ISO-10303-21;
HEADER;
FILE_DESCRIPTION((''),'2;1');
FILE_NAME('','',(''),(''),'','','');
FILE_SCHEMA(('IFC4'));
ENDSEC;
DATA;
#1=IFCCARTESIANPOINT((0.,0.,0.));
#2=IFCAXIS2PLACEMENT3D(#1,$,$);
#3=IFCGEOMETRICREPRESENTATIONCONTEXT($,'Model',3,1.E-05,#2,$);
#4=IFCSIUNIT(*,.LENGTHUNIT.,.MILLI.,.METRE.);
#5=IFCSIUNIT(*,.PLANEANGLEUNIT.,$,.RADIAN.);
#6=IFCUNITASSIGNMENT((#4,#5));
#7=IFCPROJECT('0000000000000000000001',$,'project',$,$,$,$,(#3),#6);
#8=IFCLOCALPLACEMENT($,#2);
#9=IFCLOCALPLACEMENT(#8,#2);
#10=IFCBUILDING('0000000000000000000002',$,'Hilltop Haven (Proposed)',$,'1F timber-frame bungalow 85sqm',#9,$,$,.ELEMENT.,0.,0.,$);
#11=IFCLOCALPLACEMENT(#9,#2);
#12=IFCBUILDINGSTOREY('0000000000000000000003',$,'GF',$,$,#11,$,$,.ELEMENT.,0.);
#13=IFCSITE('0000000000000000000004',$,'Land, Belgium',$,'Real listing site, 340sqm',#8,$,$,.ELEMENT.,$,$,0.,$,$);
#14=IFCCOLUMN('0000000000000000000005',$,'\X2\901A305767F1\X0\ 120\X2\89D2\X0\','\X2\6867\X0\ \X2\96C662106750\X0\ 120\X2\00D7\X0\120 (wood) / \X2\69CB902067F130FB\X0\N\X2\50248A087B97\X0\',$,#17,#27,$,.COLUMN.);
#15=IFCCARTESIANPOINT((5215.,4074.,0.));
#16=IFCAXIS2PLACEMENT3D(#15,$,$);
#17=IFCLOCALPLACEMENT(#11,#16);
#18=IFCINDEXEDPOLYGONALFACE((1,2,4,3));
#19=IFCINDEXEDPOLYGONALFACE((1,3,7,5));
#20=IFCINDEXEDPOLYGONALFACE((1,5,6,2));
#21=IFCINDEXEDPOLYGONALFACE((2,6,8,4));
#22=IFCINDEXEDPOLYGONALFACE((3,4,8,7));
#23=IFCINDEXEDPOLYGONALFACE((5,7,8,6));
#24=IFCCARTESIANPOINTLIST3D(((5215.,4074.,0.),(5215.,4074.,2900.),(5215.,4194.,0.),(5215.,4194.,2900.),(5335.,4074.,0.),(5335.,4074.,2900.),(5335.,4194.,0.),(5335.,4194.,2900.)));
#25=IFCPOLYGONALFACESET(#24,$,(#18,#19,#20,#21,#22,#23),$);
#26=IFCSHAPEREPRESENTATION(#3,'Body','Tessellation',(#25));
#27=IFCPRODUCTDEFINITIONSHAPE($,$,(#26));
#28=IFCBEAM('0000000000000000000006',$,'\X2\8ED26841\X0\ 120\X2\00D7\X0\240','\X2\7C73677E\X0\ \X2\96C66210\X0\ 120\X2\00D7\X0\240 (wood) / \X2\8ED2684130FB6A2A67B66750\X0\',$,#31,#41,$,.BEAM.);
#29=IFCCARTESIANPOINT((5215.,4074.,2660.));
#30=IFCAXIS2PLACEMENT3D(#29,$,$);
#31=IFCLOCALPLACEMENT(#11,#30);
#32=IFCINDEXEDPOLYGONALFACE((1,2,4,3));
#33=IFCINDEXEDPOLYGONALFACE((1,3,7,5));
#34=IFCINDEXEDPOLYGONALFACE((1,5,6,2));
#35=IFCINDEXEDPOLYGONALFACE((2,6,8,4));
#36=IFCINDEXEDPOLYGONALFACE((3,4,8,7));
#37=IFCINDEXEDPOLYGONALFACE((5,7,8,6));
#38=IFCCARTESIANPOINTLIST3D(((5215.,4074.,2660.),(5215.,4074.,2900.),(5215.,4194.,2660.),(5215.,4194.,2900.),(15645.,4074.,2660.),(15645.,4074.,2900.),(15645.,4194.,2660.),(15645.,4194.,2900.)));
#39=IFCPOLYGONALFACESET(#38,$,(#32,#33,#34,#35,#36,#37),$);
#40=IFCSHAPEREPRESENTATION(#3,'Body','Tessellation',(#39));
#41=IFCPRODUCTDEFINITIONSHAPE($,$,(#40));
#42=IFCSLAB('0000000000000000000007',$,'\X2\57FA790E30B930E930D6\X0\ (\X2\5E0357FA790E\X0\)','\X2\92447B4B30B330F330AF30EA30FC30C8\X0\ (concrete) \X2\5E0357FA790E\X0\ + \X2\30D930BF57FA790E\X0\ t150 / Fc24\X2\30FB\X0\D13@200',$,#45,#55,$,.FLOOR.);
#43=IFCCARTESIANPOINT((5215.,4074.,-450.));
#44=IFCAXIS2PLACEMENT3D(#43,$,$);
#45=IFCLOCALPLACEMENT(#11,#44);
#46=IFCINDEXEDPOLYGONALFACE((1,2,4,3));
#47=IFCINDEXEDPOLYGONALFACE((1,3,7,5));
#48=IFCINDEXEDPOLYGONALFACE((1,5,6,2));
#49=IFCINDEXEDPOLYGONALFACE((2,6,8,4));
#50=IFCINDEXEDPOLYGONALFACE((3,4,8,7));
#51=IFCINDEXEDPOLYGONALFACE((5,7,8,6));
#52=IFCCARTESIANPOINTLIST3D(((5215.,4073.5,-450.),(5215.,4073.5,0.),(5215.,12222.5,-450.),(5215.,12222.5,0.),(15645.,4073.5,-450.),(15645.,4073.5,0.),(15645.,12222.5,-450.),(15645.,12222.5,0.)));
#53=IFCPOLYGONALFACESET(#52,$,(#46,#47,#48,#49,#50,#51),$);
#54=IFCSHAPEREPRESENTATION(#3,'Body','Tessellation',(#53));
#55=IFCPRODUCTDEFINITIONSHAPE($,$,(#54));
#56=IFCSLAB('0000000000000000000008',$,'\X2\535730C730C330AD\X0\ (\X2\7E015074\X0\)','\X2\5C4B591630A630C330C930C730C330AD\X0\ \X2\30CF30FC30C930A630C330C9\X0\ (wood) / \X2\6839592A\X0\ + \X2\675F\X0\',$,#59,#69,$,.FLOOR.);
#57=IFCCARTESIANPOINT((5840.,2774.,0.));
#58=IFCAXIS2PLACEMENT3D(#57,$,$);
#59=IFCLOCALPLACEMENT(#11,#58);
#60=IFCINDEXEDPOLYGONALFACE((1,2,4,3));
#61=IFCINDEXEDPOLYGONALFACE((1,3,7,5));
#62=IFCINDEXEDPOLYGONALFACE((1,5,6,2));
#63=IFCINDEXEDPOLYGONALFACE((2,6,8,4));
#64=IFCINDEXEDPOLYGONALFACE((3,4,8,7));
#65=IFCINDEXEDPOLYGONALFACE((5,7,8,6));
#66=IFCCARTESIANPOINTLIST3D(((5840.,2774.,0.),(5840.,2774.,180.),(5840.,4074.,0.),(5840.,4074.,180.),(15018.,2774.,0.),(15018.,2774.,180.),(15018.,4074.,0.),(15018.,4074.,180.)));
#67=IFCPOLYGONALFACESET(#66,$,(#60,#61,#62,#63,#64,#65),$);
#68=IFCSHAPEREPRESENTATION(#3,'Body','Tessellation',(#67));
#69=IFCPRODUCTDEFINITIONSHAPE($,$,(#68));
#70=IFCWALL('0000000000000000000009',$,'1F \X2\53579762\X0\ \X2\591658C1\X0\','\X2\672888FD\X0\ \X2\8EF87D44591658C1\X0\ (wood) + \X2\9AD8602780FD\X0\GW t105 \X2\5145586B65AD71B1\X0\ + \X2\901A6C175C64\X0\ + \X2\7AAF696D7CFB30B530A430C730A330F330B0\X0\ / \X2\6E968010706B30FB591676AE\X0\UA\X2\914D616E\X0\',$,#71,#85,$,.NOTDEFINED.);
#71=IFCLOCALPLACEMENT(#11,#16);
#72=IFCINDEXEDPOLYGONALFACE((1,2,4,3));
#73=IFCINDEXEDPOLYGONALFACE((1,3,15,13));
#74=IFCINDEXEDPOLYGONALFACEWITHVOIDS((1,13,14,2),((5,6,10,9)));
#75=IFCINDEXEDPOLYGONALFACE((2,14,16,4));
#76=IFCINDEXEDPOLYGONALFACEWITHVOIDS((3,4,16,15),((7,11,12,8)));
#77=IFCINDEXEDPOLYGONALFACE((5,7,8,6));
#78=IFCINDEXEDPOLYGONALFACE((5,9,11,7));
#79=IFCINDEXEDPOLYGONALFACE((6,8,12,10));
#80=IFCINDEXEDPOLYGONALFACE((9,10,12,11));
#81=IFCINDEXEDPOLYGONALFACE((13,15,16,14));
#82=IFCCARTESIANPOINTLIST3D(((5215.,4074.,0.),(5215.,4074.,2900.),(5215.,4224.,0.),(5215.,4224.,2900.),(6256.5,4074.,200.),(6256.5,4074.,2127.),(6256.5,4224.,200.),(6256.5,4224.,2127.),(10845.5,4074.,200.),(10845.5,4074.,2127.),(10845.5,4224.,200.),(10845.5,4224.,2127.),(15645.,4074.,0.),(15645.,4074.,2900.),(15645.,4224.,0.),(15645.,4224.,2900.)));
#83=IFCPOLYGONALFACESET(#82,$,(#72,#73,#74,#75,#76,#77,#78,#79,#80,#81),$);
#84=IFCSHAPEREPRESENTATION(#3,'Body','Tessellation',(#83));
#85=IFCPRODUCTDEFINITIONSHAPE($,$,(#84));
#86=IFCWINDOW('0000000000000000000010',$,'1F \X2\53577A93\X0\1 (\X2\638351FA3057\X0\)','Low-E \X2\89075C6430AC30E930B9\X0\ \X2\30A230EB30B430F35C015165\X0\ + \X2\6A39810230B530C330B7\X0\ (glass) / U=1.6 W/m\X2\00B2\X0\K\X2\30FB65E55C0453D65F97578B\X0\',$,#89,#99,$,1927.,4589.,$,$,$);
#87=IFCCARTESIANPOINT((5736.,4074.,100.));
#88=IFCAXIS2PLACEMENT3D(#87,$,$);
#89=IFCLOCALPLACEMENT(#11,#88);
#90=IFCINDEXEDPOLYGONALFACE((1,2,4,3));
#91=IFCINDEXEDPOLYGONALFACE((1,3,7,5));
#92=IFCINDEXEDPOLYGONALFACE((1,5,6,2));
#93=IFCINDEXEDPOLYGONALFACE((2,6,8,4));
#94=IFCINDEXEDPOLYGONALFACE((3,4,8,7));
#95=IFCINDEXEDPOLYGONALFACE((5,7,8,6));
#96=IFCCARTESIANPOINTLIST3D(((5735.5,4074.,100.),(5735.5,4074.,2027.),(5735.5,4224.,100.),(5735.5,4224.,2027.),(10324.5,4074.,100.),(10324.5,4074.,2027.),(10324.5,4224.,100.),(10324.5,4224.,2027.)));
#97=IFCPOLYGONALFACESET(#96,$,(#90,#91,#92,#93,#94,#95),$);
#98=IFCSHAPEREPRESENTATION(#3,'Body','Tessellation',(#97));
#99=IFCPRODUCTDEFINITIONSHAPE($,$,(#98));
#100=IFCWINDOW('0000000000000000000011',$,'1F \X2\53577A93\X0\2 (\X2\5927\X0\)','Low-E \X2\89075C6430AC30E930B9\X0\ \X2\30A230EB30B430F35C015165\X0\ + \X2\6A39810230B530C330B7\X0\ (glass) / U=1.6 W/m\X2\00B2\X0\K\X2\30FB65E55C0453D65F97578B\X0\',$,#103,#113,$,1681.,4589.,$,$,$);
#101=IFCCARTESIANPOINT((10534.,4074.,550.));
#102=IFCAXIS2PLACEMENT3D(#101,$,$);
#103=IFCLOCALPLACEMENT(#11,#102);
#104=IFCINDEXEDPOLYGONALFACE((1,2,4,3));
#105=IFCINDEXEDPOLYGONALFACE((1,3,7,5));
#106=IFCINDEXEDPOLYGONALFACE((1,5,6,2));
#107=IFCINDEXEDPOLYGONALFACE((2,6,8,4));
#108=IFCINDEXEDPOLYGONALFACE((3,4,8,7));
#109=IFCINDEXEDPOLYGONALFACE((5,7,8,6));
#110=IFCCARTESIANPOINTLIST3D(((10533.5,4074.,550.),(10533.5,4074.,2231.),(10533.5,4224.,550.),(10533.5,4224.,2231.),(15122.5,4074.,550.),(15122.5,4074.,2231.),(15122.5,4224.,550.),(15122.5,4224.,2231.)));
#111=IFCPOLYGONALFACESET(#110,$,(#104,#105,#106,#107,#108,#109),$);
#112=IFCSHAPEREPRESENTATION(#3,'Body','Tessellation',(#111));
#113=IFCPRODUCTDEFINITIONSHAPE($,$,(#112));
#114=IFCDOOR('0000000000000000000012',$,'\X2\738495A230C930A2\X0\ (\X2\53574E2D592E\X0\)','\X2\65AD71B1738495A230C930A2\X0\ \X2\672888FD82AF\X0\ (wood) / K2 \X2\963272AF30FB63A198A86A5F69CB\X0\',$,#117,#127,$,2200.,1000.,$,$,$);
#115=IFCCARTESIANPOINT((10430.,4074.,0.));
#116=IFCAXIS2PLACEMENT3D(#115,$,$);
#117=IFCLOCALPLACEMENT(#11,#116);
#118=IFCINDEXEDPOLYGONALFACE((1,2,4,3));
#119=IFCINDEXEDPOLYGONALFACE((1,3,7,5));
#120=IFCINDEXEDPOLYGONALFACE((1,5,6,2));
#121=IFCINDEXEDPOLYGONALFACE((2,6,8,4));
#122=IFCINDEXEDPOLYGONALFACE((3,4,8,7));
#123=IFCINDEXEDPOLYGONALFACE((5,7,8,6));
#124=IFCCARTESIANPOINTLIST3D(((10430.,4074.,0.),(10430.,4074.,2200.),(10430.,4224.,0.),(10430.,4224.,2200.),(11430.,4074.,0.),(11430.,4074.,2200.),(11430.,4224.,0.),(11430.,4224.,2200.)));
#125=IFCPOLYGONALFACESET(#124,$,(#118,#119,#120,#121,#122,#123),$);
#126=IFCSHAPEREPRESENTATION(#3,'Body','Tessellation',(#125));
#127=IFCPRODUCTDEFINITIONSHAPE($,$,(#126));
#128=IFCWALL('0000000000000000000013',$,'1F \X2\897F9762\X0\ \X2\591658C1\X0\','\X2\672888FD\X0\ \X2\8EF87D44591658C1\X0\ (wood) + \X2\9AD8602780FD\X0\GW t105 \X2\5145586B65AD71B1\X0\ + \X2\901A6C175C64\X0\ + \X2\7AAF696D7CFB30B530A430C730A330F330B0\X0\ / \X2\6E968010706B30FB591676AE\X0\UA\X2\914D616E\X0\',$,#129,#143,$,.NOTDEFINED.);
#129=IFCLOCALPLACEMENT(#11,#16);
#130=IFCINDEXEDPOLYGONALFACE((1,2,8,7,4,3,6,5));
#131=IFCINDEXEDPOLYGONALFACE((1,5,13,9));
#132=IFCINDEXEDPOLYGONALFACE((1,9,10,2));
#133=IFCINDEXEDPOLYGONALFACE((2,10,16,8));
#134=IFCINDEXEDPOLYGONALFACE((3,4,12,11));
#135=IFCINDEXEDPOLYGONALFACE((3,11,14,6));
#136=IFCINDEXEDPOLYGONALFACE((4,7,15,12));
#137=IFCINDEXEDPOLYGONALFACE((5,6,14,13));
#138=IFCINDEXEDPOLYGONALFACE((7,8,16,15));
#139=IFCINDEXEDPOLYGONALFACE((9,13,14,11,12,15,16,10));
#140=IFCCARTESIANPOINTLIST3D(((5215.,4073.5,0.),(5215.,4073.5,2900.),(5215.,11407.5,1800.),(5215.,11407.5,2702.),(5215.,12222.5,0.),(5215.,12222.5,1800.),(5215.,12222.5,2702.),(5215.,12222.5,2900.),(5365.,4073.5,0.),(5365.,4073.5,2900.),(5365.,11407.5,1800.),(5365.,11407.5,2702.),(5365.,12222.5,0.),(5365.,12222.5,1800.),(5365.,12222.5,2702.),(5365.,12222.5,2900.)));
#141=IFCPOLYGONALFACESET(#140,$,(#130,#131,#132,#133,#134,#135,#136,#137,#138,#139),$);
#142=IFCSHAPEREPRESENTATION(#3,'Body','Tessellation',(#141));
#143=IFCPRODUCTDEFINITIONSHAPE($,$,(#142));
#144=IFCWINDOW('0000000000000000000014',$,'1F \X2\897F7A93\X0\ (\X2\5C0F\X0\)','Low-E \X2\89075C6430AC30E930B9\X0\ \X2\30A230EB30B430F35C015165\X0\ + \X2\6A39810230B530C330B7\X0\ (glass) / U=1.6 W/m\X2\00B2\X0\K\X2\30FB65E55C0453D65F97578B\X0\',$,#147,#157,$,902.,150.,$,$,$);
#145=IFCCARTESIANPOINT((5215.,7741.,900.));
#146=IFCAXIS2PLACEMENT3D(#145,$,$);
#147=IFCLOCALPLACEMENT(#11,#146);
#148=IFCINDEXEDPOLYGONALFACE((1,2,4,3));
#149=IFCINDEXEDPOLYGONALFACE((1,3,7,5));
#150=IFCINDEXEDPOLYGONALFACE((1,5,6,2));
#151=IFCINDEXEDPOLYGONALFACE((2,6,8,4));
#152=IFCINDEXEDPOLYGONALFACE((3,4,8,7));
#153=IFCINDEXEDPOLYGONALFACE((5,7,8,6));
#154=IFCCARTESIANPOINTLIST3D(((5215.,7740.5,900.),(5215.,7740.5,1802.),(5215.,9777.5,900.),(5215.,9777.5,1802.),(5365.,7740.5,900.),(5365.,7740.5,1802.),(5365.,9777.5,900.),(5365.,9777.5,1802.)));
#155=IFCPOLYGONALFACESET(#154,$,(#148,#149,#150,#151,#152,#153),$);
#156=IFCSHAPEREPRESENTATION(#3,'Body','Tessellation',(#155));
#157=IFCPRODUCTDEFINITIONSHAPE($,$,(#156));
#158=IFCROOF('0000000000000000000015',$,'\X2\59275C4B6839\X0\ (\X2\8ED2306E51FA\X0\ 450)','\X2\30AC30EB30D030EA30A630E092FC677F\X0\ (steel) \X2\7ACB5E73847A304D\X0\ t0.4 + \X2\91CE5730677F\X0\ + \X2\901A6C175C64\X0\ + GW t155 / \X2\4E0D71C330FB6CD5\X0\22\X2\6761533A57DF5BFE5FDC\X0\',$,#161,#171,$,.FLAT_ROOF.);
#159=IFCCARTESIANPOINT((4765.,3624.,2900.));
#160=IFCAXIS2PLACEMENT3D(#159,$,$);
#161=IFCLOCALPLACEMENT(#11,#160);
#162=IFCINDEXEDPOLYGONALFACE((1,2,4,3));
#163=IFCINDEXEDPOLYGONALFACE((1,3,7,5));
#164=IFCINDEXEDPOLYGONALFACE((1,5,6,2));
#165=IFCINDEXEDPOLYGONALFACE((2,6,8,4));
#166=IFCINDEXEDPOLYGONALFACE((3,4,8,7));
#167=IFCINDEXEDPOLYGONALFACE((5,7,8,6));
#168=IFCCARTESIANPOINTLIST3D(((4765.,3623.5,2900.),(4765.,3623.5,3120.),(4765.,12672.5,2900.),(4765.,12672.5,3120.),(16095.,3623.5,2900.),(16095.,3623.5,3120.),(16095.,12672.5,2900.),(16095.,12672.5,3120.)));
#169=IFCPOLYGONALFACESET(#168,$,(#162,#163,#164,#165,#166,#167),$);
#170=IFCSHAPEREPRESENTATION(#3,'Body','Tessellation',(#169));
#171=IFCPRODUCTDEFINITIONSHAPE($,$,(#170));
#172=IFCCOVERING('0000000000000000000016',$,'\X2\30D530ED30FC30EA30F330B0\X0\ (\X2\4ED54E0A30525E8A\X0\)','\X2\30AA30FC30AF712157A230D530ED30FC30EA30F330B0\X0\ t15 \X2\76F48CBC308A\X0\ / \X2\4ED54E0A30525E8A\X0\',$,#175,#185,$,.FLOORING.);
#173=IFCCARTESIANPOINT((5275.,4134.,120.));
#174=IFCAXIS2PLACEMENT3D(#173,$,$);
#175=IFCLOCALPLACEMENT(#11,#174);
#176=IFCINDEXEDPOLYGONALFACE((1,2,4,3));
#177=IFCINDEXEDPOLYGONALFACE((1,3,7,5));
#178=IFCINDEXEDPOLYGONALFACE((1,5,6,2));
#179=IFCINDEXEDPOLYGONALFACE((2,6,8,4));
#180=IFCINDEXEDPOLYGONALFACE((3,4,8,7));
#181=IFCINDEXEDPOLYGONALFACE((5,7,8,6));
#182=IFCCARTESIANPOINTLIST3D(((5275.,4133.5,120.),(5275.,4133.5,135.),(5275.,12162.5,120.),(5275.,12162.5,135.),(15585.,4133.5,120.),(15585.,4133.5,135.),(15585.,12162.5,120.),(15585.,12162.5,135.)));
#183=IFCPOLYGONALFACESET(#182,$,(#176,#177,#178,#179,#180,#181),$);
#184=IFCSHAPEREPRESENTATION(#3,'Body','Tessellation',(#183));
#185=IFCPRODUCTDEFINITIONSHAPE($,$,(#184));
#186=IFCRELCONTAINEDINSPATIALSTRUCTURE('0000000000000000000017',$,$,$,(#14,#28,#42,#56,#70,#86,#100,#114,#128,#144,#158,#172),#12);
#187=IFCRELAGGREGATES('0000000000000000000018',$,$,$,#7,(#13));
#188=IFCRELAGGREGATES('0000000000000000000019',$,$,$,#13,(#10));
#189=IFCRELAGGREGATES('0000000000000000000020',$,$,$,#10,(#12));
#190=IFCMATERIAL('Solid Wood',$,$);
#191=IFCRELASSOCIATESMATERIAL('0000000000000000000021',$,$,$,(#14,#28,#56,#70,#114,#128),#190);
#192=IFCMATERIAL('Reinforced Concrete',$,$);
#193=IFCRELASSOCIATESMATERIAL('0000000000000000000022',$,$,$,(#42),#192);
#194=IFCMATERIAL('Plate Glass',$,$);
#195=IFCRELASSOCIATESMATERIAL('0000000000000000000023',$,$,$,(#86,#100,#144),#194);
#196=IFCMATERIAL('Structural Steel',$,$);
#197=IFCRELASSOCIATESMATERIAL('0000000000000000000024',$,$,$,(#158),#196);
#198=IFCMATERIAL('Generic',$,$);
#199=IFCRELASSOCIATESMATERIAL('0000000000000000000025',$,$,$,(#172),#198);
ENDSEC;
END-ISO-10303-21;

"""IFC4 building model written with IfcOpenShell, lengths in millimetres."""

from ifc_helpers import new_model, si_unit, frame, frame_2d, origin, place, context, project, spatial, rectangle, extrude, material, element, fill, save


model = new_model("IFC4")

# Units and contexts
model_context = context("Model", 3, precision=1e-05, world=origin())
ifc_project = project(units=[si_unit("LENGTHUNIT", "METRE", prefix="MILLI"), si_unit("PLANEANGLEUNIT", "RADIAN")], contexts=[model_context])

# Site, building, storey
site_placement = place(None, origin())
site = spatial("IfcSite", under=ifc_project, at=site_placement, Name="Land, Belgium", ObjectType="Real listing site, 340sqm", CompositionType="ELEMENT", RefElevation=0.0)
building_placement = place(site_placement, origin())
building = spatial("IfcBuilding", under=site, at=building_placement, Name="Hilltop Haven (Proposed)", ObjectType="1F timber-frame bungalow 85sqm", CompositionType="ELEMENT", ElevationOfRefHeight=0.0, ElevationOfTerrain=0.0)
storey_placement = place(building_placement, origin())
storey = spatial("IfcBuildingStorey", under=building, at=storey_placement, Name="GF", CompositionType="ELEMENT", Elevation=0.0)

# Column
ifc_material_1 = material(Name="Solid Wood")
column_1_placement = place(storey_placement, frame((5215.0, 4074.0, 0.0)))
element("IfcColumn", 1, at=column_1_placement, inside=storey, material=ifc_material_1, Name="通し柱 120角", Description="桧 集成材 120×120 (wood) / 構造柱・N値計算", PredefinedType="COLUMN", context=model_context, shape_type="SweptSolid", body=[
    extrude(rectangle(XDim=120.0, YDim=120.0, at=frame_2d((60.0, 60.0))), frame((5215.0, 4074.0, 0.0)), (0.0, 0.0, 1.0), 2900.0),
])

# Beam
beam_1_placement = place(storey_placement, frame((5215.0, 4074.0, 2660.0)))
element("IfcBeam", 2, at=beam_1_placement, inside=storey, material=ifc_material_1, Name="軒桁 120×240", Description="米松 集成 120×240 (wood) / 軒桁・横架材", PredefinedType="BEAM", context=model_context, shape_type="SweptSolid", body=[
    extrude(rectangle(XDim=10430.0, YDim=120.0, at=frame_2d((5215.0, 60.0))), frame((5215.0, 4074.0, 2660.0)), (0.0, 0.0, 1.0), 240.0),
])

# Slabs
ifc_material_2 = material(Name="Reinforced Concrete")
slab_1_placement = place(storey_placement, frame((5215.0, 4074.0, -450.0)))
element("IfcSlab", 3, at=slab_1_placement, inside=storey, material=ifc_material_2, Name="基礎スラブ (布基礎)", Description="鉄筋コンクリート (concrete) 布基礎 + ベタ基礎 t150 / Fc24・D13@200", PredefinedType="FLOOR", context=model_context, shape_type="SweptSolid", body=[
    extrude(rectangle(XDim=10430.0, YDim=8149.0, at=frame_2d((5215.0, 4074.0))), frame((5215.0, 4074.0, -450.0)), (0.0, 0.0, 1.0), 450.0),
])
slab_2_placement = place(storey_placement, frame((5840.0, 2774.0, 0.0)))
element("IfcSlab", 4, at=slab_2_placement, inside=storey, material=ifc_material_1, Name="南デッキ (縁側)", Description="屋外ウッドデッキ ハードウッド (wood) / 根太 + 束", PredefinedType="FLOOR", context=model_context, shape_type="SweptSolid", body=[
    extrude(rectangle(XDim=9178.0, YDim=1300.0, at=frame_2d((4589.0, 650.0))), frame((5840.0, 2774.0, 0.0)), (0.0, 0.0, 1.0), 180.0),
])

# Wall, openings, windows, door
wall_1_placement = place(storey_placement, frame((5215.0, 4074.0, 0.0)))
wall_1 = element("IfcWall", 5, at=wall_1_placement, inside=storey, material=ifc_material_1, Name="1F 南面 外壁", Description="木製 軸組外壁 (wood) + 高性能GW t105 充填断熱 + 通気層 + 窯業系サイディング / 準耐火・外皮UA配慮", PredefinedType="NOTDEFINED", context=model_context, shape_type="SweptSolid", body=[
    extrude(rectangle(XDim=10430.0, YDim=150.0, at=frame_2d((5215.0, 75.0))), frame((5215.0, 4074.0, 0.0)), (0.0, 0.0, 1.0), 2900.0),
])
opening_1_placement = place(storey_placement, frame((5736.0, 4074.0, 100.0)))
opening_1 = element("IfcOpeningElement", 6, at=opening_1_placement, cuts=wall_1, PredefinedType="NOTDEFINED", context=model_context, shape_type="SweptSolid", body=[
    extrude(rectangle(XDim=4589.0, YDim=150.0, at=frame_2d((2294.0, 75.0))), frame((5736.0, 4074.0, 100.0)), (0.0, 0.0, 1.0), 1927.0),
])
opening_2_placement = place(storey_placement, frame((10534.0, 4074.0, 550.0)))
opening_2 = element("IfcOpeningElement", 7, at=opening_2_placement, cuts=wall_1, PredefinedType="NOTDEFINED", context=model_context, shape_type="SweptSolid", body=[
    extrude(rectangle(XDim=4589.0, YDim=150.0, at=frame_2d((2294.0, 75.0))), frame((10534.0, 4074.0, 550.0)), (0.0, 0.0, 1.0), 1681.0),
])
opening_3_placement = place(storey_placement, frame((10430.0, 4074.0, 0.0)))
opening_3 = element("IfcOpeningElement", 8, at=opening_3_placement, cuts=wall_1, PredefinedType="NOTDEFINED", context=model_context, shape_type="SweptSolid", body=[
    extrude(rectangle(XDim=1000.0, YDim=150.0, at=frame_2d((500.0, 75.0))), frame((10430.0, 4074.0, 0.0)), (0.0, 0.0, 1.0), 2200.0),
])
ifc_material_3 = material(Name="Plate Glass")
window_1_placement = place(storey_placement, frame((5736.0, 4074.0, 100.0)))
window_1 = element("IfcWindow", 9, at=window_1_placement, inside=storey, material=ifc_material_3, Name="1F 南窓1 (掃出し)", Description="Low-E 複層ガラス アルゴン封入 + 樹脂サッシ (glass) / U=1.6 W/m²K・日射取得型", OverallHeight=1927.0, OverallWidth=4589.0, context=model_context, shape_type="SweptSolid", body=[
    extrude(rectangle(XDim=4589.0, YDim=150.0, at=frame_2d((2294.0, 75.0))), frame((5736.0, 4074.0, 100.0)), (0.0, 0.0, 1.0), 1927.0),
])
fill(opening_1, window_1)
window_2_placement = place(storey_placement, frame((10534.0, 4074.0, 550.0)))
window_2 = element("IfcWindow", 10, at=window_2_placement, inside=storey, material=ifc_material_3, Name="1F 南窓2 (大)", Description="Low-E 複層ガラス アルゴン封入 + 樹脂サッシ (glass) / U=1.6 W/m²K・日射取得型", OverallHeight=1681.0, OverallWidth=4589.0, context=model_context, shape_type="SweptSolid", body=[
    extrude(rectangle(XDim=4589.0, YDim=150.0, at=frame_2d((2294.0, 75.0))), frame((10534.0, 4074.0, 550.0)), (0.0, 0.0, 1.0), 1681.0),
])
fill(opening_2, window_2)
door_placement = place(storey_placement, frame((10430.0, 4074.0, 0.0)))
door = element("IfcDoor", 11, at=door_placement, inside=storey, material=ifc_material_1, Name="玄関ドア (南中央)", Description="断熱玄関ドア 木製芯 (wood) / K2 防犯・採風機構", OverallHeight=2200.0, OverallWidth=1000.0, context=model_context, shape_type="SweptSolid", body=[
    extrude(rectangle(XDim=1000.0, YDim=150.0, at=frame_2d((500.0, 75.0))), frame((10430.0, 4074.0, 0.0)), (0.0, 0.0, 1.0), 2200.0),
])
fill(opening_3, door)

# Wall, opening, window
wall_2_placement = place(storey_placement, frame((5215.0, 4074.0, 0.0)))
wall_2 = element("IfcWall", 12, at=wall_2_placement, inside=storey, material=ifc_material_1, Name="1F 西面 外壁", Description="木製 軸組外壁 (wood) + 高性能GW t105 充填断熱 + 通気層 + 窯業系サイディング / 準耐火・外皮UA配慮", PredefinedType="NOTDEFINED", context=model_context, shape_type="SweptSolid", body=[
    extrude(rectangle(XDim=150.0, YDim=8149.0, at=frame_2d((75.0, 4074.0))), frame((5215.0, 4074.0, 0.0)), (0.0, 0.0, 1.0), 2900.0),
])
opening_4_placement = place(storey_placement, frame((5215.0, 7741.0, 900.0)))
opening_4 = element("IfcOpeningElement", 13, at=opening_4_placement, cuts=wall_2, PredefinedType="NOTDEFINED", context=model_context, shape_type="SweptSolid", body=[
    extrude(rectangle(XDim=150.0, YDim=2037.0, at=frame_2d((75.0, 1018.0))), frame((5215.0, 7741.0, 900.0)), (0.0, 0.0, 1.0), 902.0),
])
window_3_placement = place(storey_placement, frame((5215.0, 7741.0, 900.0)))
window_3 = element("IfcWindow", 14, at=window_3_placement, inside=storey, material=ifc_material_3, Name="1F 西窓 (小)", Description="Low-E 複層ガラス アルゴン封入 + 樹脂サッシ (glass) / U=1.6 W/m²K・日射取得型", OverallHeight=902.0, OverallWidth=150.0, context=model_context, shape_type="SweptSolid", body=[
    extrude(rectangle(XDim=150.0, YDim=2037.0, at=frame_2d((75.0, 1018.0))), frame((5215.0, 7741.0, 900.0)), (0.0, 0.0, 1.0), 902.0),
])
fill(opening_4, window_3)

# Roof
ifc_material_4 = material(Name="Structural Steel")
roof_placement = place(storey_placement, frame((4765.0, 3624.0, 2900.0)))
element("IfcRoof", 15, at=roof_placement, inside=storey, material=ifc_material_4, Name="大屋根 (軒の出 450)", Description="ガルバリウム鋼板 (steel) 立平葺き t0.4 + 野地板 + 通気層 + GW t155 / 不燃・法22条区域対応", PredefinedType="FLAT_ROOF", context=model_context, shape_type="SweptSolid", body=[
    extrude(rectangle(XDim=11330.0, YDim=9049.0, at=frame_2d((5665.0, 4524.0))), frame((4765.0, 3624.0, 2900.0)), (0.0, 0.0, 1.0), 220.0),
])

# Covering
ifc_material_5 = material(Name="Generic")
covering_1_placement = place(storey_placement, frame((5275.0, 4134.0, 120.0)))
element("IfcCovering", 16, at=covering_1_placement, inside=storey, material=ifc_material_5, Name="フローリング (仕上げ床)", Description="オーク無垢フローリング t15 直貼り / 仕上げ床", PredefinedType="FLOORING", context=model_context, shape_type="SweptSolid", body=[
    extrude(rectangle(XDim=10310.0, YDim=8029.0, at=frame_2d((5155.0, 4014.0))), frame((5275.0, 4134.0, 120.0)), (0.0, 0.0, 1.0), 15.0),
])

save(model, "model.ifc")
